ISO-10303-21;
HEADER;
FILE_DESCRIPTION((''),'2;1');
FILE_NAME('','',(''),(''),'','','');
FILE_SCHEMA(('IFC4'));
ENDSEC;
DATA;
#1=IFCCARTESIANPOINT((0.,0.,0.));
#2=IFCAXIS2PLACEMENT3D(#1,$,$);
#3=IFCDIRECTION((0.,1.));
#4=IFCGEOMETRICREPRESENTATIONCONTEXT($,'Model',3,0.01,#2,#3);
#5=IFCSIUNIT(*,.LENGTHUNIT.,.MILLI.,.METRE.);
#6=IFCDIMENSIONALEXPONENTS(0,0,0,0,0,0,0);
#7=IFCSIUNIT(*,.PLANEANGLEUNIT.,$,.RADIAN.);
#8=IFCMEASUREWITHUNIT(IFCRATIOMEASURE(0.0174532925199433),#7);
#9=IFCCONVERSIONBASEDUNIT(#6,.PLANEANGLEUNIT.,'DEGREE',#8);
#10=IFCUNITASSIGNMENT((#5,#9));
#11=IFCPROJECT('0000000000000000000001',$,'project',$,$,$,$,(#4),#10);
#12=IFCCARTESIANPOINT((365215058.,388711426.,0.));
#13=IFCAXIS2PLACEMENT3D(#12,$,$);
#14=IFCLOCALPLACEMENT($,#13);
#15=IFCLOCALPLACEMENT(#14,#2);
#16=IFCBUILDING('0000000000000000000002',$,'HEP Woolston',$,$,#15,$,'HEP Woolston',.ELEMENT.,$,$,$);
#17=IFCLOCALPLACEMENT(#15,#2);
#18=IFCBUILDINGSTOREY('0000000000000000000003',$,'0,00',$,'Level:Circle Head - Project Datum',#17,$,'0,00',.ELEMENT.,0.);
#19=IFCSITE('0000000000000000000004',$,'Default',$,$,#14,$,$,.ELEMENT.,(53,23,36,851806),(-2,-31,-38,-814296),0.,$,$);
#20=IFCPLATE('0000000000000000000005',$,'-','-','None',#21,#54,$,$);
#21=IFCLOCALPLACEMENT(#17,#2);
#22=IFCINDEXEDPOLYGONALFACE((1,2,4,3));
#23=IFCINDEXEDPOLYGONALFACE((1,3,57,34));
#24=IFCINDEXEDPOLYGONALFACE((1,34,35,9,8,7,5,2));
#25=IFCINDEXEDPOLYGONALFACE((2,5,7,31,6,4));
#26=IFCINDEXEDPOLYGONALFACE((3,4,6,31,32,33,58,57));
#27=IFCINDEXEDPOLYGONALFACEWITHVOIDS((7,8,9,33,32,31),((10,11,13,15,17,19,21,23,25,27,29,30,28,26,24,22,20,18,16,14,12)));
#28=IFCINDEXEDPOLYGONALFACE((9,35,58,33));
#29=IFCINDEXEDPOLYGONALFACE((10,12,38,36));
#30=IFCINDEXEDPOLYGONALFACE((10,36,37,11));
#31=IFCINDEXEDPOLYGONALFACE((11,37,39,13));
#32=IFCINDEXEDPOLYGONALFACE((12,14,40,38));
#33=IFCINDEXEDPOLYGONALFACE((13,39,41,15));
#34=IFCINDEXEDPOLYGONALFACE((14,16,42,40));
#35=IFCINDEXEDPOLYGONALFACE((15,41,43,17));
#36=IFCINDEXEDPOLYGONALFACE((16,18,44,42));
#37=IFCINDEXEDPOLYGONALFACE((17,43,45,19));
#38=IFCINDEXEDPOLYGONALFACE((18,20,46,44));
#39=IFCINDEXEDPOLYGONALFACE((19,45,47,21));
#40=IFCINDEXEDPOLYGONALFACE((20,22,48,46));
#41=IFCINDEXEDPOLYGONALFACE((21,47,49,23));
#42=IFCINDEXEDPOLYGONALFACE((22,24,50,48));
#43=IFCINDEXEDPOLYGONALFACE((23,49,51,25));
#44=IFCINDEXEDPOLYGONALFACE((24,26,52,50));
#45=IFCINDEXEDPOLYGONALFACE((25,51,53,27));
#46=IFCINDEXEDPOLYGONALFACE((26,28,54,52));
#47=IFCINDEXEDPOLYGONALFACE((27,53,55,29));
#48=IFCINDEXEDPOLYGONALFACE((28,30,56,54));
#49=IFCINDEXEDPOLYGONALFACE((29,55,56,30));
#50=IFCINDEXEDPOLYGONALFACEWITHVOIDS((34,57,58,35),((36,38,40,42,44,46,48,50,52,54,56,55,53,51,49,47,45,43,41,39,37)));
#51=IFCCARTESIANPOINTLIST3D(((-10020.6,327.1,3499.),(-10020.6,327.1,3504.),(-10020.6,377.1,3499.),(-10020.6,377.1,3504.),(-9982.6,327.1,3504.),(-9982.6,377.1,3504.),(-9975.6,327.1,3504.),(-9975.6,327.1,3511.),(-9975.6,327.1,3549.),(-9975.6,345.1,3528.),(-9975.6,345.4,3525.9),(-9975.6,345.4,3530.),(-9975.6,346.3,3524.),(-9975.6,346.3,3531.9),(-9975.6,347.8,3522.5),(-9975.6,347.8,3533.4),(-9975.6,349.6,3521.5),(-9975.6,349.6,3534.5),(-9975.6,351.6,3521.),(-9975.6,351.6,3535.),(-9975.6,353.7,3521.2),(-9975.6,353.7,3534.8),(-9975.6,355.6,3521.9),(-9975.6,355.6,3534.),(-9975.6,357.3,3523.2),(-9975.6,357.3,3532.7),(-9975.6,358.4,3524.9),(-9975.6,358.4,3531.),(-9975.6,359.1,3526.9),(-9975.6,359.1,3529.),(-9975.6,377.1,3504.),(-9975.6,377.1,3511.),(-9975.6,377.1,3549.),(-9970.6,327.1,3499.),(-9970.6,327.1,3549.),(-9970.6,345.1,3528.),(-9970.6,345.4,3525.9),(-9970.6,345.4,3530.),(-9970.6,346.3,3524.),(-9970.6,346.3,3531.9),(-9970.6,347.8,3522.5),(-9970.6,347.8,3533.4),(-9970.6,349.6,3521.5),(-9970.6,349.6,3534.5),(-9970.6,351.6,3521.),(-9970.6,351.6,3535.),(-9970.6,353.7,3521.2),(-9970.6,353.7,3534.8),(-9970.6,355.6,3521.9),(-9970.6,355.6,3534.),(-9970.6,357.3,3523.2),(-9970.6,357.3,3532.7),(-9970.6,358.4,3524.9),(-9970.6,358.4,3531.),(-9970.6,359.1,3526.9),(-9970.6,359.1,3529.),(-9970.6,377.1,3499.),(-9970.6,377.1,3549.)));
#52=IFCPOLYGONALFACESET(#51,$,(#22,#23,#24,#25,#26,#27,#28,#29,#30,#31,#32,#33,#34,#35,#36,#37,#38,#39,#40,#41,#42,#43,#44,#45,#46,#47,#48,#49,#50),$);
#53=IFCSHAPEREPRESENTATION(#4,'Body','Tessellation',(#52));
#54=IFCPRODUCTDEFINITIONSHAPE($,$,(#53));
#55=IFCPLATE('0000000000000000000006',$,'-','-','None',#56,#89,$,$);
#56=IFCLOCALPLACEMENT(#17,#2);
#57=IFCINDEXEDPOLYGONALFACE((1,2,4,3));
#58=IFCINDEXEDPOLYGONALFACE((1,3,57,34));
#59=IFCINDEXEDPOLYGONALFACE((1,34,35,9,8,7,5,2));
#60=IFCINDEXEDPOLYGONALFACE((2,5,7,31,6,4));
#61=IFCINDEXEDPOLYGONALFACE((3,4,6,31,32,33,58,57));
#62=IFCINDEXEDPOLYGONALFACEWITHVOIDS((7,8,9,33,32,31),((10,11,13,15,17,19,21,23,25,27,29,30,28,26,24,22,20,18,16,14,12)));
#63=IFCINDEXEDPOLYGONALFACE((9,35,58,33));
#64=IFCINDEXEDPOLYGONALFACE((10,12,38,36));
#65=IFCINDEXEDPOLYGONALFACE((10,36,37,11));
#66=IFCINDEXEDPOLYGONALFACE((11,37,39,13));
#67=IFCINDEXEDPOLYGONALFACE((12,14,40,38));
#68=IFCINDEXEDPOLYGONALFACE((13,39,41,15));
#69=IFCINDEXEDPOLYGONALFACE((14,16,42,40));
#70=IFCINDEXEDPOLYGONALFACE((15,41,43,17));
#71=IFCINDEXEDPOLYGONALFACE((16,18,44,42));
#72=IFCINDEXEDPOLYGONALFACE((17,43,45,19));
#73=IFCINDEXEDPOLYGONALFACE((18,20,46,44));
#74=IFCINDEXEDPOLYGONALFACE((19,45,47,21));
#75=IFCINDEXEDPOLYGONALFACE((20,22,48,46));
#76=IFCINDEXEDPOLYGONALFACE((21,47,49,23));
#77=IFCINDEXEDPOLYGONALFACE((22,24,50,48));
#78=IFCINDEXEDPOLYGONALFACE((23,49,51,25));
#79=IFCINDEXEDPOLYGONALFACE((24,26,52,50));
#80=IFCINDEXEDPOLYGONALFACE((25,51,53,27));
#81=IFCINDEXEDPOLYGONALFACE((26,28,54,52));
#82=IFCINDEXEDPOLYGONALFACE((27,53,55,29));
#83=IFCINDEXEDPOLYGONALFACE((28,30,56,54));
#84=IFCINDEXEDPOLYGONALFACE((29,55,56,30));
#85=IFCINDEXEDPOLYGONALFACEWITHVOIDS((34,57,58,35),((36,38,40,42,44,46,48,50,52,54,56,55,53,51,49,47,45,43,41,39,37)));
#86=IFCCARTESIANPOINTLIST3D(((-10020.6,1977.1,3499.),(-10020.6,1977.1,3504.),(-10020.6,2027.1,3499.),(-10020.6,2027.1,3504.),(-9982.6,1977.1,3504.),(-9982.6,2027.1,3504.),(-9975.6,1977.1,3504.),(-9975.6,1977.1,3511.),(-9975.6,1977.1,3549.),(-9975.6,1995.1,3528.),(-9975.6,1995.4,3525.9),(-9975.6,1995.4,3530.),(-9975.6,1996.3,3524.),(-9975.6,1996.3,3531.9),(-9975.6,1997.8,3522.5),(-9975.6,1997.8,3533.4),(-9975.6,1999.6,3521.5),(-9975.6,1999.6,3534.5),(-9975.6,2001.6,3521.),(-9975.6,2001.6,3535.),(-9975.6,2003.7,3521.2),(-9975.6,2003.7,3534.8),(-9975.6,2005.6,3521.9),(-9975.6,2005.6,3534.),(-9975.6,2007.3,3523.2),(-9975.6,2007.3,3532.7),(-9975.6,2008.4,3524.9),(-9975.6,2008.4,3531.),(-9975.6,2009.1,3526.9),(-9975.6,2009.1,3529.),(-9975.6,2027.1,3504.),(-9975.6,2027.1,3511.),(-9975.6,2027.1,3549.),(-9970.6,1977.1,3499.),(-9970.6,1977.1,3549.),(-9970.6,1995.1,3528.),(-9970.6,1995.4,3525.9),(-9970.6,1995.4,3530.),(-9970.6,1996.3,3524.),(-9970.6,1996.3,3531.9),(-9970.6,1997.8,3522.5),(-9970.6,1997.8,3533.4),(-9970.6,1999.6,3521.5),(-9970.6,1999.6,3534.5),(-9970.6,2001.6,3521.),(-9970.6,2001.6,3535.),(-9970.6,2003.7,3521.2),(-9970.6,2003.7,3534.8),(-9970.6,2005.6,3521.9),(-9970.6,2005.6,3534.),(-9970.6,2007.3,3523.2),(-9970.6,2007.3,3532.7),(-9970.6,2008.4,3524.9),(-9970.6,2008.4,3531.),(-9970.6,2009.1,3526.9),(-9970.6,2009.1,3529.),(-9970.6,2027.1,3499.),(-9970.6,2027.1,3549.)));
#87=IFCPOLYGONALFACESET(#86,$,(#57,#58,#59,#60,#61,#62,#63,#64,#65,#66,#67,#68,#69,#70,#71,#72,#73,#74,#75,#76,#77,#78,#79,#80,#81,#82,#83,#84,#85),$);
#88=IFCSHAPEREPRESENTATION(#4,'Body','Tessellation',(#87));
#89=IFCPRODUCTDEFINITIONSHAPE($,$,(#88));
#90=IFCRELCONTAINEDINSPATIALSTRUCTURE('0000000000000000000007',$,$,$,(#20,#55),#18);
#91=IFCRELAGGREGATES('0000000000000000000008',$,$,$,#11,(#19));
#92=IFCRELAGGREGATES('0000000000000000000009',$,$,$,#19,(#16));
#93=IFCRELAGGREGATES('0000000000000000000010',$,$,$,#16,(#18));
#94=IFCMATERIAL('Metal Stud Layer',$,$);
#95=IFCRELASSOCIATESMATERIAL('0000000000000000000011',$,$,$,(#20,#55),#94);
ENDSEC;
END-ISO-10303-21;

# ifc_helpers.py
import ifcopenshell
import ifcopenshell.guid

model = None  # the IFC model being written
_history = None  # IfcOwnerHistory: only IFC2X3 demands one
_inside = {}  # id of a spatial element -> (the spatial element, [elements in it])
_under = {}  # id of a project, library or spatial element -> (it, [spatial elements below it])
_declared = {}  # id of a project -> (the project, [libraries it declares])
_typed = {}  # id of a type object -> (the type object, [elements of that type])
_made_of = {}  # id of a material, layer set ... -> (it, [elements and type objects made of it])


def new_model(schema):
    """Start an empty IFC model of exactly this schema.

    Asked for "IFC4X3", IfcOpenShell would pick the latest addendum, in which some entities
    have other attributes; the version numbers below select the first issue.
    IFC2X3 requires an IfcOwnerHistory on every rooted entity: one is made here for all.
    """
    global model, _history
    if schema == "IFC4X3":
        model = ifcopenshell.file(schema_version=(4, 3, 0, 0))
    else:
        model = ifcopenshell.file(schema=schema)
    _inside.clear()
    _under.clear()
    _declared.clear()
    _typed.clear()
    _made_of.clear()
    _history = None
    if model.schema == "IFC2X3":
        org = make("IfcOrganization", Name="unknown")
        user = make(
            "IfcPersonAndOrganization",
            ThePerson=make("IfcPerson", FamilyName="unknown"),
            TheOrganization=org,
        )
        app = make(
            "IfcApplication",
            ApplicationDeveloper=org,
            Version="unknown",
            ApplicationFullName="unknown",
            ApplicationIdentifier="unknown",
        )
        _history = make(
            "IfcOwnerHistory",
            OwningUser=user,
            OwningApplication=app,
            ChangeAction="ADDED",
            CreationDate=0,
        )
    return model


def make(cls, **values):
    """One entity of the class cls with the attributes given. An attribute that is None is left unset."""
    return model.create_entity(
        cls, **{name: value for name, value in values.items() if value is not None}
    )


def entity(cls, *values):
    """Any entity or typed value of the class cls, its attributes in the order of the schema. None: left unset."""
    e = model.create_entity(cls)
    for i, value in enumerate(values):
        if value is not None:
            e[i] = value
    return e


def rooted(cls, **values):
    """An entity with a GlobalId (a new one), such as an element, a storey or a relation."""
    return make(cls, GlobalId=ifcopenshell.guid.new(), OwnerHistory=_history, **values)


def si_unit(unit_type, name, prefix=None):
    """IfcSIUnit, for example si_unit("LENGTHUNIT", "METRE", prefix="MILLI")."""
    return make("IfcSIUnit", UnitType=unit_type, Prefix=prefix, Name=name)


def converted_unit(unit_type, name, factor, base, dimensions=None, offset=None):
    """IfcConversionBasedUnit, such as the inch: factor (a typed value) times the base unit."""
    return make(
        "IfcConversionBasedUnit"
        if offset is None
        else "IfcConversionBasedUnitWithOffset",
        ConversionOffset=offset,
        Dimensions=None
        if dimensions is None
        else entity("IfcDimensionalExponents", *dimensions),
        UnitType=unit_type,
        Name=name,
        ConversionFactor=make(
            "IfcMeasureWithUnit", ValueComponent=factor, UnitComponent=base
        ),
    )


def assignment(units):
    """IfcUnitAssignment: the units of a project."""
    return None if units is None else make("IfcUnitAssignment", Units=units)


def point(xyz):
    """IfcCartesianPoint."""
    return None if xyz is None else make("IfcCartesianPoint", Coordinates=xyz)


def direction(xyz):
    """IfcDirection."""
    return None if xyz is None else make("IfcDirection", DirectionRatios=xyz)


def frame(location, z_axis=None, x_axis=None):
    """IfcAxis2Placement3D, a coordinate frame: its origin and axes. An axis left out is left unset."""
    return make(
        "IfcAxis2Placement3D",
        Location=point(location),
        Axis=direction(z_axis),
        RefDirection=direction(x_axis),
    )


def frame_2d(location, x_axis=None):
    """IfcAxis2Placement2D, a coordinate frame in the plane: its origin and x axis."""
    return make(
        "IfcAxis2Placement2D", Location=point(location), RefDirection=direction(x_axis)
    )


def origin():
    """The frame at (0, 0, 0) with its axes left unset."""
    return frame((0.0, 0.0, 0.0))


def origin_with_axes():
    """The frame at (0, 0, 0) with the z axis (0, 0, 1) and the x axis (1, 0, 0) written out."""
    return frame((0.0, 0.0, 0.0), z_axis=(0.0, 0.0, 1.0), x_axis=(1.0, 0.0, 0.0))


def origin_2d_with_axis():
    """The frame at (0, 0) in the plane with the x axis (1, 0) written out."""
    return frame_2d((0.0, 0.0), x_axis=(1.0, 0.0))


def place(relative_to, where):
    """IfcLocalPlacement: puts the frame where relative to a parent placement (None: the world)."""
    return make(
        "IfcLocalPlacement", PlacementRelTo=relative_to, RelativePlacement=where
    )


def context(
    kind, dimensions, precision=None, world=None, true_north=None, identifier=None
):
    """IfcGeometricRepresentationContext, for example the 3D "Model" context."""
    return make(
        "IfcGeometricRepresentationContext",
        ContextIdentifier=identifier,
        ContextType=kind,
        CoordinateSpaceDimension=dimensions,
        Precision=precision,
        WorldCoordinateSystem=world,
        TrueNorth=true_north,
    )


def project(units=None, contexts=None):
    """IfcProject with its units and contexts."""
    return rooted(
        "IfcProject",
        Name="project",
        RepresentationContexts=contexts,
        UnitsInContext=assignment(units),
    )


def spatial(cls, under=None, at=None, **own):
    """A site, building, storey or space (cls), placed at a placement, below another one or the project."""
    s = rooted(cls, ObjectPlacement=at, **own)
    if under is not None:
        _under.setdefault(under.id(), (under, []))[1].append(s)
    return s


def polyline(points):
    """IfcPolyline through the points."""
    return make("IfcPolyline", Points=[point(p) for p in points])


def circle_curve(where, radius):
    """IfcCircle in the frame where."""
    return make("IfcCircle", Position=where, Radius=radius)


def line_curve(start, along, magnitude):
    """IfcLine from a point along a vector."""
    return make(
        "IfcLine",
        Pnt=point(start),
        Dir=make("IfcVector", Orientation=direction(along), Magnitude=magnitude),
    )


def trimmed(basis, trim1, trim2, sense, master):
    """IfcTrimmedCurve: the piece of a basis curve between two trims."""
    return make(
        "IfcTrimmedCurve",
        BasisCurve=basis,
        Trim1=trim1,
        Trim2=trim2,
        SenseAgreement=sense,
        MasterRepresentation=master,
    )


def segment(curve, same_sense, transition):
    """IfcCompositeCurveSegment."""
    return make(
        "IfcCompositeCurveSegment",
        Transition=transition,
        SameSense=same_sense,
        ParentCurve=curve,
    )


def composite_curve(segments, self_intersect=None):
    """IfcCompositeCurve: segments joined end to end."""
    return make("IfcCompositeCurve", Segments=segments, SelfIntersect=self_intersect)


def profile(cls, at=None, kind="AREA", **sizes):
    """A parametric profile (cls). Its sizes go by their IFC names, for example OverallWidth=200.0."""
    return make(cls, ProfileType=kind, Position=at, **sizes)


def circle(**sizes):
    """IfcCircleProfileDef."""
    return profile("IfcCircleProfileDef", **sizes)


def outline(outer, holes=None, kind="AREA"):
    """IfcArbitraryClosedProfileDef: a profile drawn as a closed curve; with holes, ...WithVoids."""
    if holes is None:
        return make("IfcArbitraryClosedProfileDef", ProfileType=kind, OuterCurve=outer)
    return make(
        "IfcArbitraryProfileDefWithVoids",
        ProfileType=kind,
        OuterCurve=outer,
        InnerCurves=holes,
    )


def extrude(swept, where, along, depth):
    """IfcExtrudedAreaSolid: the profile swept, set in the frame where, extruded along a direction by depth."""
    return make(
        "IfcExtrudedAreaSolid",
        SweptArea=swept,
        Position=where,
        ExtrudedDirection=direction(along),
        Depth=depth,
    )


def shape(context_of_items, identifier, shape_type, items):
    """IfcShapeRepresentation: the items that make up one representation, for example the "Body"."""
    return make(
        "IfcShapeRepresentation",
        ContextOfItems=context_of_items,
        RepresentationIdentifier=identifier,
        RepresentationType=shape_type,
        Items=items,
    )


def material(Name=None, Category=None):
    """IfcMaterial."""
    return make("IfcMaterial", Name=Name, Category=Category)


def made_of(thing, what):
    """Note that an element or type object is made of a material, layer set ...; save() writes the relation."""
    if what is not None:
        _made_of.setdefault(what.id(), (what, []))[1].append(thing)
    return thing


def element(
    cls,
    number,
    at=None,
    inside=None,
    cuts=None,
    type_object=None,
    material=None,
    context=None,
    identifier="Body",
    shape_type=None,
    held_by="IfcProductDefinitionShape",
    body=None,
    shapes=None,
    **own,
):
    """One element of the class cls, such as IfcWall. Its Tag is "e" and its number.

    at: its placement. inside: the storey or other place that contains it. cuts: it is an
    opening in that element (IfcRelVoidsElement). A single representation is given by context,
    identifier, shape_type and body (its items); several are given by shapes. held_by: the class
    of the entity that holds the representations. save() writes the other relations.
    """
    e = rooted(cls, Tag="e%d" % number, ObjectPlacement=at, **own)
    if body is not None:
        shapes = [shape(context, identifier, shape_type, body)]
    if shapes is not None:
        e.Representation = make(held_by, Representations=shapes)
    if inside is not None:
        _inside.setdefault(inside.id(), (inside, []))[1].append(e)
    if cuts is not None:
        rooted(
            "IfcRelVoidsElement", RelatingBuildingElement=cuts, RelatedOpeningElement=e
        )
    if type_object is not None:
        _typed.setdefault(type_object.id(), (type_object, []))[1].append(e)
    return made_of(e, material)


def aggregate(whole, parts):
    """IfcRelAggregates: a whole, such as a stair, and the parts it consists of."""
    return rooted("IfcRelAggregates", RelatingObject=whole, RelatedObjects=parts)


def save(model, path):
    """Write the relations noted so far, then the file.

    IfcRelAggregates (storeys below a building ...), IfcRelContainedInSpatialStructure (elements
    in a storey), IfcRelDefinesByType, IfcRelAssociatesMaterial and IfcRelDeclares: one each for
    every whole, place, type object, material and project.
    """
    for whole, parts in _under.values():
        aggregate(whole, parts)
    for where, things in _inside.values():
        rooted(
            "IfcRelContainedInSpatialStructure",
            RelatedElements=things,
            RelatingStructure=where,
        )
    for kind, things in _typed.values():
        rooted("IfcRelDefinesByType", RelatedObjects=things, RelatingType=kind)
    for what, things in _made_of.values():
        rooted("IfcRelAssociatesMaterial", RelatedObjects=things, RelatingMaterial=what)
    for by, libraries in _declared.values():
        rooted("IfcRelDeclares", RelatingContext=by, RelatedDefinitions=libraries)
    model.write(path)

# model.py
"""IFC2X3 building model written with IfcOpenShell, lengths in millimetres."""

from ifc_helpers import new_model, entity, si_unit, converted_unit, point, direction, frame, frame_2d, origin, origin_with_axes, origin_2d_with_axis, place, context, project, spatial, polyline, circle_curve, line_curve, trimmed, segment, composite_curve, circle, outline, extrude, material, element, save


model = new_model("IFC2X3")

# Units and contexts
model_context = context("Model", 3, precision=0.01, world=origin(), true_north=direction((0.0, 1.0)))
ifc_project = project(units=[si_unit("LENGTHUNIT", "METRE", prefix="MILLI"), converted_unit("PLANEANGLEUNIT", "DEGREE", entity("IfcRatioMeasure", 0.0174532925199433), si_unit("PLANEANGLEUNIT", "RADIAN"), dimensions=[0, 0, 0, 0, 0, 0, 0])], contexts=[model_context])

# Site, building, storey
site_placement = place(None, frame((365215058.0, 388711426.0, 0.0)))
site = spatial("IfcSite", under=ifc_project, at=site_placement, Name="Default", CompositionType="ELEMENT", RefLatitude=(53, 23, 36, 851806), RefLongitude=(-2, -31, -38, -814296), RefElevation=0.0)
building_placement = place(site_placement, origin())
building = spatial("IfcBuilding", under=site, at=building_placement, Name="HEP Woolston", LongName="HEP Woolston", CompositionType="ELEMENT")
storey_placement = place(building_placement, origin())
storey = spatial("IfcBuildingStorey", under=building, at=storey_placement, Name="0,00", ObjectType="Level:Circle Head - Project Datum", LongName="0,00", CompositionType="ELEMENT", Elevation=0.0)

# Plates, openings
ifc_material = material(Name="Metal Stud Layer")
plate_1_placement = place(storey_placement, frame((-9970.6, 327.1, 3499.0), z_axis=(0.0, 1.0, 0.0), x_axis=(-1.0, 0.0, 0.0)))
plate_1 = element("IfcPlate", 1, at=plate_1_placement, inside=storey, material=ifc_material, Name="-", Description="-", ObjectType="None", context=model_context, shape_type="SweptSolid", body=[
    extrude(outline(polyline([(0.0, 0.0), (50.0, 0.0), (50.0, 5.0), (5.0, 5.0), (5.0, 50.0), (0.0, 50.0), (0.0, 0.0)])), origin_with_axes(), (0.0, 0.0, 1.0), 50.0),
])
opening_1_placement = place(plate_1_placement, frame((0.0, 0.0, 0.0), z_axis=(0.0, 0.0, 1.0), x_axis=(1.0, 0.0, 0.0)))
element("IfcOpeningElement", 2, at=opening_1_placement, cuts=plate_1, ObjectType="Opening", context=model_context, shape_type="SweptSolid", body=[
    extrude(outline(composite_curve([segment(trimmed(line_curve((50.0, 5.0), (1.0, 0.0), 3.532613), [point((50.0, 5.0))], [point((46.5, 5.0))], True, "CARTESIAN"), True, "CONTINUOUS"), segment(trimmed(circle_curve(frame_2d((46.5, 1.5), x_axis=(-1.0, 0.0)), 3.5), [point((46.5, 5.0))], [point((50.0, 1.5))], False, "CARTESIAN"), True, "CONTINUOUS"), segment(trimmed(line_curve((50.0, 1.5), (0.0, -1.0), 3.532613), [point((50.0, 1.5))], [point((50.0, 5.0))], True, "CARTESIAN"), True, "CONTINUOUS")], self_intersect="UNKNOWN")), origin(), (0.0, 0.0, 1.0), 50.0),
])
opening_2_placement = place(plate_1_placement, origin_with_axes())
element("IfcOpeningElement", 3, at=opening_2_placement, cuts=plate_1, ObjectType="Opening", context=model_context, shape_type="SweptSolid", body=[
    extrude(outline(composite_curve([segment(trimmed(line_curve((5.0, 5.0), (0.0, -1.0), 7.046301), [point((5.0, 5.0))], [point((5.0, 12.0))], False, "CARTESIAN"), True, "CONTINUOUS"), segment(trimmed(circle_curve(frame_2d((12.0, 12.0), x_axis=(1.0, 0.0)), 7.0), [point((5.0, 12.0))], [point((12.0, 5.0))], True, "CARTESIAN"), True, "CONTINUOUS"), segment(trimmed(line_curve((12.0, 5.0), (1.0, 0.0), 7.046301), [point((12.0, 5.0))], [point((5.0, 5.0))], False, "CARTESIAN"), True, "CONTINUOUS")], self_intersect="UNKNOWN")), origin(), (0.0, 0.0, 1.0), 50.0),
])
opening_3_placement = place(plate_1_placement, frame((0.0, 0.0, 0.0), z_axis=(0.0, 0.0, 1.0), x_axis=(1.0, 0.0, 0.0)))
element("IfcOpeningElement", 4, at=opening_3_placement, cuts=plate_1, ObjectType="Opening", context=model_context, shape_type="SweptSolid", body=[
    extrude(outline(composite_curve([segment(trimmed(line_curve((5.0, 50.0), (1.0, 0.0), 3.4874), [point((5.0, 50.0))], [point((1.5, 50.0))], True, "CARTESIAN"), True, "CONTINUOUS"), segment(trimmed(circle_curve(frame_2d((1.5, 46.5), x_axis=(-1.0, 0.0)), 3.5), [point((1.5, 50.0))], [point((5.0, 46.5))], False, "CARTESIAN"), True, "CONTINUOUS"), segment(trimmed(line_curve((5.0, 46.5), (0.0, -1.0), 3.4874), [point((5.0, 46.5))], [point((5.0, 50.0))], True, "CARTESIAN"), True, "CONTINUOUS")], self_intersect="UNKNOWN")), origin(), (0.0, 0.0, 1.0), 50.0),
])
opening_4_placement = place(plate_1_placement, frame((-0.5, 29.0, 25.0), z_axis=(1.0, 0.0, 0.0), x_axis=(0.0, 0.0, -1.0)))
element("IfcOpeningElement", 5, at=opening_4_placement, cuts=plate_1, ObjectType="Opening", context=model_context, shape_type="SweptSolid", body=[
    extrude(circle(Radius=7.0, at=origin_2d_with_axis()), origin(), (0.0, 0.0, 1.0), 6.0),
])
plate_2_placement = place(storey_placement, frame((-9970.6, 1977.1, 3499.0), z_axis=(0.0, 1.0, 0.0), x_axis=(-1.0, 0.0, 0.0)))
plate_2 = element("IfcPlate", 6, at=plate_2_placement, inside=storey, material=ifc_material, Name="-", Description="-", ObjectType="None", context=model_context, shape_type="SweptSolid", body=[
    extrude(outline(polyline([(0.0, 0.0), (50.0, 0.0), (50.0, 5.0), (5.0, 5.0), (5.0, 50.0), (0.0, 50.0), (0.0, 0.0)])), origin_with_axes(), (0.0, 0.0, 1.0), 50.0),
])
opening_5_placement = place(plate_2_placement, frame((0.0, 0.0, 0.0), z_axis=(0.0, 0.0, 1.0), x_axis=(1.0, 0.0, 0.0)))
element("IfcOpeningElement", 7, at=opening_5_placement, cuts=plate_2, ObjectType="Opening", context=model_context, shape_type="SweptSolid", body=[
    extrude(outline(composite_curve([segment(trimmed(line_curve((50.0, 5.0), (1.0, 0.0), 3.532613), [point((50.0, 5.0))], [point((46.5, 5.0))], True, "CARTESIAN"), True, "CONTINUOUS"), segment(trimmed(circle_curve(frame_2d((46.5, 1.5), x_axis=(-1.0, 0.0)), 3.5), [point((46.5, 5.0))], [point((50.0, 1.5))], False, "CARTESIAN"), True, "CONTINUOUS"), segment(trimmed(line_curve((50.0, 1.5), (0.0, -1.0), 3.532613), [point((50.0, 1.5))], [point((50.0, 5.0))], True, "CARTESIAN"), True, "CONTINUOUS")], self_intersect="UNKNOWN")), origin(), (0.0, 0.0, 1.0), 50.0),
])
opening_6_placement = place(plate_2_placement, origin_with_axes())
element("IfcOpeningElement", 8, at=opening_6_placement, cuts=plate_2, ObjectType="Opening", context=model_context, shape_type="SweptSolid", body=[
    extrude(outline(composite_curve([segment(trimmed(line_curve((5.0, 5.0), (0.0, -1.0), 7.046301), [point((5.0, 5.0))], [point((5.0, 12.0))], False, "CARTESIAN"), True, "CONTINUOUS"), segment(trimmed(circle_curve(frame_2d((12.0, 12.0), x_axis=(1.0, 0.0)), 7.0), [point((5.0, 12.0))], [point((12.0, 5.0))], True, "CARTESIAN"), True, "CONTINUOUS"), segment(trimmed(line_curve((12.0, 5.0), (1.0, 0.0), 7.046301), [point((12.0, 5.0))], [point((5.0, 5.0))], False, "CARTESIAN"), True, "CONTINUOUS")], self_intersect="UNKNOWN")), origin(), (0.0, 0.0, 1.0), 50.0),
])
opening_7_placement = place(plate_2_placement, frame((0.0, 0.0, 0.0), z_axis=(0.0, 0.0, 1.0), x_axis=(1.0, 0.0, 0.0)))
element("IfcOpeningElement", 9, at=opening_7_placement, cuts=plate_2, ObjectType="Opening", context=model_context, shape_type="SweptSolid", body=[
    extrude(outline(composite_curve([segment(trimmed(line_curve((5.0, 50.0), (1.0, 0.0), 3.4874), [point((5.0, 50.0))], [point((1.5, 50.0))], True, "CARTESIAN"), True, "CONTINUOUS"), segment(trimmed(circle_curve(frame_2d((1.5, 46.5), x_axis=(-1.0, 0.0)), 3.5), [point((1.5, 50.0))], [point((5.0, 46.5))], False, "CARTESIAN"), True, "CONTINUOUS"), segment(trimmed(line_curve((5.0, 46.5), (0.0, -1.0), 3.4874), [point((5.0, 46.5))], [point((5.0, 50.0))], True, "CARTESIAN"), True, "CONTINUOUS")], self_intersect="UNKNOWN")), origin(), (0.0, 0.0, 1.0), 50.0),
])
opening_8_placement = place(plate_2_placement, frame((-0.5, 29.0, 25.0), z_axis=(1.0, 0.0, 0.0), x_axis=(0.0, 0.0, -1.0)))
element("IfcOpeningElement", 10, at=opening_8_placement, cuts=plate_2, ObjectType="Opening", context=model_context, shape_type="SweptSolid", body=[
    extrude(circle(Radius=7.0, at=origin_2d_with_axis()), origin(), (0.0, 0.0, 1.0), 6.0),
])

save(model, "model.ifc")
